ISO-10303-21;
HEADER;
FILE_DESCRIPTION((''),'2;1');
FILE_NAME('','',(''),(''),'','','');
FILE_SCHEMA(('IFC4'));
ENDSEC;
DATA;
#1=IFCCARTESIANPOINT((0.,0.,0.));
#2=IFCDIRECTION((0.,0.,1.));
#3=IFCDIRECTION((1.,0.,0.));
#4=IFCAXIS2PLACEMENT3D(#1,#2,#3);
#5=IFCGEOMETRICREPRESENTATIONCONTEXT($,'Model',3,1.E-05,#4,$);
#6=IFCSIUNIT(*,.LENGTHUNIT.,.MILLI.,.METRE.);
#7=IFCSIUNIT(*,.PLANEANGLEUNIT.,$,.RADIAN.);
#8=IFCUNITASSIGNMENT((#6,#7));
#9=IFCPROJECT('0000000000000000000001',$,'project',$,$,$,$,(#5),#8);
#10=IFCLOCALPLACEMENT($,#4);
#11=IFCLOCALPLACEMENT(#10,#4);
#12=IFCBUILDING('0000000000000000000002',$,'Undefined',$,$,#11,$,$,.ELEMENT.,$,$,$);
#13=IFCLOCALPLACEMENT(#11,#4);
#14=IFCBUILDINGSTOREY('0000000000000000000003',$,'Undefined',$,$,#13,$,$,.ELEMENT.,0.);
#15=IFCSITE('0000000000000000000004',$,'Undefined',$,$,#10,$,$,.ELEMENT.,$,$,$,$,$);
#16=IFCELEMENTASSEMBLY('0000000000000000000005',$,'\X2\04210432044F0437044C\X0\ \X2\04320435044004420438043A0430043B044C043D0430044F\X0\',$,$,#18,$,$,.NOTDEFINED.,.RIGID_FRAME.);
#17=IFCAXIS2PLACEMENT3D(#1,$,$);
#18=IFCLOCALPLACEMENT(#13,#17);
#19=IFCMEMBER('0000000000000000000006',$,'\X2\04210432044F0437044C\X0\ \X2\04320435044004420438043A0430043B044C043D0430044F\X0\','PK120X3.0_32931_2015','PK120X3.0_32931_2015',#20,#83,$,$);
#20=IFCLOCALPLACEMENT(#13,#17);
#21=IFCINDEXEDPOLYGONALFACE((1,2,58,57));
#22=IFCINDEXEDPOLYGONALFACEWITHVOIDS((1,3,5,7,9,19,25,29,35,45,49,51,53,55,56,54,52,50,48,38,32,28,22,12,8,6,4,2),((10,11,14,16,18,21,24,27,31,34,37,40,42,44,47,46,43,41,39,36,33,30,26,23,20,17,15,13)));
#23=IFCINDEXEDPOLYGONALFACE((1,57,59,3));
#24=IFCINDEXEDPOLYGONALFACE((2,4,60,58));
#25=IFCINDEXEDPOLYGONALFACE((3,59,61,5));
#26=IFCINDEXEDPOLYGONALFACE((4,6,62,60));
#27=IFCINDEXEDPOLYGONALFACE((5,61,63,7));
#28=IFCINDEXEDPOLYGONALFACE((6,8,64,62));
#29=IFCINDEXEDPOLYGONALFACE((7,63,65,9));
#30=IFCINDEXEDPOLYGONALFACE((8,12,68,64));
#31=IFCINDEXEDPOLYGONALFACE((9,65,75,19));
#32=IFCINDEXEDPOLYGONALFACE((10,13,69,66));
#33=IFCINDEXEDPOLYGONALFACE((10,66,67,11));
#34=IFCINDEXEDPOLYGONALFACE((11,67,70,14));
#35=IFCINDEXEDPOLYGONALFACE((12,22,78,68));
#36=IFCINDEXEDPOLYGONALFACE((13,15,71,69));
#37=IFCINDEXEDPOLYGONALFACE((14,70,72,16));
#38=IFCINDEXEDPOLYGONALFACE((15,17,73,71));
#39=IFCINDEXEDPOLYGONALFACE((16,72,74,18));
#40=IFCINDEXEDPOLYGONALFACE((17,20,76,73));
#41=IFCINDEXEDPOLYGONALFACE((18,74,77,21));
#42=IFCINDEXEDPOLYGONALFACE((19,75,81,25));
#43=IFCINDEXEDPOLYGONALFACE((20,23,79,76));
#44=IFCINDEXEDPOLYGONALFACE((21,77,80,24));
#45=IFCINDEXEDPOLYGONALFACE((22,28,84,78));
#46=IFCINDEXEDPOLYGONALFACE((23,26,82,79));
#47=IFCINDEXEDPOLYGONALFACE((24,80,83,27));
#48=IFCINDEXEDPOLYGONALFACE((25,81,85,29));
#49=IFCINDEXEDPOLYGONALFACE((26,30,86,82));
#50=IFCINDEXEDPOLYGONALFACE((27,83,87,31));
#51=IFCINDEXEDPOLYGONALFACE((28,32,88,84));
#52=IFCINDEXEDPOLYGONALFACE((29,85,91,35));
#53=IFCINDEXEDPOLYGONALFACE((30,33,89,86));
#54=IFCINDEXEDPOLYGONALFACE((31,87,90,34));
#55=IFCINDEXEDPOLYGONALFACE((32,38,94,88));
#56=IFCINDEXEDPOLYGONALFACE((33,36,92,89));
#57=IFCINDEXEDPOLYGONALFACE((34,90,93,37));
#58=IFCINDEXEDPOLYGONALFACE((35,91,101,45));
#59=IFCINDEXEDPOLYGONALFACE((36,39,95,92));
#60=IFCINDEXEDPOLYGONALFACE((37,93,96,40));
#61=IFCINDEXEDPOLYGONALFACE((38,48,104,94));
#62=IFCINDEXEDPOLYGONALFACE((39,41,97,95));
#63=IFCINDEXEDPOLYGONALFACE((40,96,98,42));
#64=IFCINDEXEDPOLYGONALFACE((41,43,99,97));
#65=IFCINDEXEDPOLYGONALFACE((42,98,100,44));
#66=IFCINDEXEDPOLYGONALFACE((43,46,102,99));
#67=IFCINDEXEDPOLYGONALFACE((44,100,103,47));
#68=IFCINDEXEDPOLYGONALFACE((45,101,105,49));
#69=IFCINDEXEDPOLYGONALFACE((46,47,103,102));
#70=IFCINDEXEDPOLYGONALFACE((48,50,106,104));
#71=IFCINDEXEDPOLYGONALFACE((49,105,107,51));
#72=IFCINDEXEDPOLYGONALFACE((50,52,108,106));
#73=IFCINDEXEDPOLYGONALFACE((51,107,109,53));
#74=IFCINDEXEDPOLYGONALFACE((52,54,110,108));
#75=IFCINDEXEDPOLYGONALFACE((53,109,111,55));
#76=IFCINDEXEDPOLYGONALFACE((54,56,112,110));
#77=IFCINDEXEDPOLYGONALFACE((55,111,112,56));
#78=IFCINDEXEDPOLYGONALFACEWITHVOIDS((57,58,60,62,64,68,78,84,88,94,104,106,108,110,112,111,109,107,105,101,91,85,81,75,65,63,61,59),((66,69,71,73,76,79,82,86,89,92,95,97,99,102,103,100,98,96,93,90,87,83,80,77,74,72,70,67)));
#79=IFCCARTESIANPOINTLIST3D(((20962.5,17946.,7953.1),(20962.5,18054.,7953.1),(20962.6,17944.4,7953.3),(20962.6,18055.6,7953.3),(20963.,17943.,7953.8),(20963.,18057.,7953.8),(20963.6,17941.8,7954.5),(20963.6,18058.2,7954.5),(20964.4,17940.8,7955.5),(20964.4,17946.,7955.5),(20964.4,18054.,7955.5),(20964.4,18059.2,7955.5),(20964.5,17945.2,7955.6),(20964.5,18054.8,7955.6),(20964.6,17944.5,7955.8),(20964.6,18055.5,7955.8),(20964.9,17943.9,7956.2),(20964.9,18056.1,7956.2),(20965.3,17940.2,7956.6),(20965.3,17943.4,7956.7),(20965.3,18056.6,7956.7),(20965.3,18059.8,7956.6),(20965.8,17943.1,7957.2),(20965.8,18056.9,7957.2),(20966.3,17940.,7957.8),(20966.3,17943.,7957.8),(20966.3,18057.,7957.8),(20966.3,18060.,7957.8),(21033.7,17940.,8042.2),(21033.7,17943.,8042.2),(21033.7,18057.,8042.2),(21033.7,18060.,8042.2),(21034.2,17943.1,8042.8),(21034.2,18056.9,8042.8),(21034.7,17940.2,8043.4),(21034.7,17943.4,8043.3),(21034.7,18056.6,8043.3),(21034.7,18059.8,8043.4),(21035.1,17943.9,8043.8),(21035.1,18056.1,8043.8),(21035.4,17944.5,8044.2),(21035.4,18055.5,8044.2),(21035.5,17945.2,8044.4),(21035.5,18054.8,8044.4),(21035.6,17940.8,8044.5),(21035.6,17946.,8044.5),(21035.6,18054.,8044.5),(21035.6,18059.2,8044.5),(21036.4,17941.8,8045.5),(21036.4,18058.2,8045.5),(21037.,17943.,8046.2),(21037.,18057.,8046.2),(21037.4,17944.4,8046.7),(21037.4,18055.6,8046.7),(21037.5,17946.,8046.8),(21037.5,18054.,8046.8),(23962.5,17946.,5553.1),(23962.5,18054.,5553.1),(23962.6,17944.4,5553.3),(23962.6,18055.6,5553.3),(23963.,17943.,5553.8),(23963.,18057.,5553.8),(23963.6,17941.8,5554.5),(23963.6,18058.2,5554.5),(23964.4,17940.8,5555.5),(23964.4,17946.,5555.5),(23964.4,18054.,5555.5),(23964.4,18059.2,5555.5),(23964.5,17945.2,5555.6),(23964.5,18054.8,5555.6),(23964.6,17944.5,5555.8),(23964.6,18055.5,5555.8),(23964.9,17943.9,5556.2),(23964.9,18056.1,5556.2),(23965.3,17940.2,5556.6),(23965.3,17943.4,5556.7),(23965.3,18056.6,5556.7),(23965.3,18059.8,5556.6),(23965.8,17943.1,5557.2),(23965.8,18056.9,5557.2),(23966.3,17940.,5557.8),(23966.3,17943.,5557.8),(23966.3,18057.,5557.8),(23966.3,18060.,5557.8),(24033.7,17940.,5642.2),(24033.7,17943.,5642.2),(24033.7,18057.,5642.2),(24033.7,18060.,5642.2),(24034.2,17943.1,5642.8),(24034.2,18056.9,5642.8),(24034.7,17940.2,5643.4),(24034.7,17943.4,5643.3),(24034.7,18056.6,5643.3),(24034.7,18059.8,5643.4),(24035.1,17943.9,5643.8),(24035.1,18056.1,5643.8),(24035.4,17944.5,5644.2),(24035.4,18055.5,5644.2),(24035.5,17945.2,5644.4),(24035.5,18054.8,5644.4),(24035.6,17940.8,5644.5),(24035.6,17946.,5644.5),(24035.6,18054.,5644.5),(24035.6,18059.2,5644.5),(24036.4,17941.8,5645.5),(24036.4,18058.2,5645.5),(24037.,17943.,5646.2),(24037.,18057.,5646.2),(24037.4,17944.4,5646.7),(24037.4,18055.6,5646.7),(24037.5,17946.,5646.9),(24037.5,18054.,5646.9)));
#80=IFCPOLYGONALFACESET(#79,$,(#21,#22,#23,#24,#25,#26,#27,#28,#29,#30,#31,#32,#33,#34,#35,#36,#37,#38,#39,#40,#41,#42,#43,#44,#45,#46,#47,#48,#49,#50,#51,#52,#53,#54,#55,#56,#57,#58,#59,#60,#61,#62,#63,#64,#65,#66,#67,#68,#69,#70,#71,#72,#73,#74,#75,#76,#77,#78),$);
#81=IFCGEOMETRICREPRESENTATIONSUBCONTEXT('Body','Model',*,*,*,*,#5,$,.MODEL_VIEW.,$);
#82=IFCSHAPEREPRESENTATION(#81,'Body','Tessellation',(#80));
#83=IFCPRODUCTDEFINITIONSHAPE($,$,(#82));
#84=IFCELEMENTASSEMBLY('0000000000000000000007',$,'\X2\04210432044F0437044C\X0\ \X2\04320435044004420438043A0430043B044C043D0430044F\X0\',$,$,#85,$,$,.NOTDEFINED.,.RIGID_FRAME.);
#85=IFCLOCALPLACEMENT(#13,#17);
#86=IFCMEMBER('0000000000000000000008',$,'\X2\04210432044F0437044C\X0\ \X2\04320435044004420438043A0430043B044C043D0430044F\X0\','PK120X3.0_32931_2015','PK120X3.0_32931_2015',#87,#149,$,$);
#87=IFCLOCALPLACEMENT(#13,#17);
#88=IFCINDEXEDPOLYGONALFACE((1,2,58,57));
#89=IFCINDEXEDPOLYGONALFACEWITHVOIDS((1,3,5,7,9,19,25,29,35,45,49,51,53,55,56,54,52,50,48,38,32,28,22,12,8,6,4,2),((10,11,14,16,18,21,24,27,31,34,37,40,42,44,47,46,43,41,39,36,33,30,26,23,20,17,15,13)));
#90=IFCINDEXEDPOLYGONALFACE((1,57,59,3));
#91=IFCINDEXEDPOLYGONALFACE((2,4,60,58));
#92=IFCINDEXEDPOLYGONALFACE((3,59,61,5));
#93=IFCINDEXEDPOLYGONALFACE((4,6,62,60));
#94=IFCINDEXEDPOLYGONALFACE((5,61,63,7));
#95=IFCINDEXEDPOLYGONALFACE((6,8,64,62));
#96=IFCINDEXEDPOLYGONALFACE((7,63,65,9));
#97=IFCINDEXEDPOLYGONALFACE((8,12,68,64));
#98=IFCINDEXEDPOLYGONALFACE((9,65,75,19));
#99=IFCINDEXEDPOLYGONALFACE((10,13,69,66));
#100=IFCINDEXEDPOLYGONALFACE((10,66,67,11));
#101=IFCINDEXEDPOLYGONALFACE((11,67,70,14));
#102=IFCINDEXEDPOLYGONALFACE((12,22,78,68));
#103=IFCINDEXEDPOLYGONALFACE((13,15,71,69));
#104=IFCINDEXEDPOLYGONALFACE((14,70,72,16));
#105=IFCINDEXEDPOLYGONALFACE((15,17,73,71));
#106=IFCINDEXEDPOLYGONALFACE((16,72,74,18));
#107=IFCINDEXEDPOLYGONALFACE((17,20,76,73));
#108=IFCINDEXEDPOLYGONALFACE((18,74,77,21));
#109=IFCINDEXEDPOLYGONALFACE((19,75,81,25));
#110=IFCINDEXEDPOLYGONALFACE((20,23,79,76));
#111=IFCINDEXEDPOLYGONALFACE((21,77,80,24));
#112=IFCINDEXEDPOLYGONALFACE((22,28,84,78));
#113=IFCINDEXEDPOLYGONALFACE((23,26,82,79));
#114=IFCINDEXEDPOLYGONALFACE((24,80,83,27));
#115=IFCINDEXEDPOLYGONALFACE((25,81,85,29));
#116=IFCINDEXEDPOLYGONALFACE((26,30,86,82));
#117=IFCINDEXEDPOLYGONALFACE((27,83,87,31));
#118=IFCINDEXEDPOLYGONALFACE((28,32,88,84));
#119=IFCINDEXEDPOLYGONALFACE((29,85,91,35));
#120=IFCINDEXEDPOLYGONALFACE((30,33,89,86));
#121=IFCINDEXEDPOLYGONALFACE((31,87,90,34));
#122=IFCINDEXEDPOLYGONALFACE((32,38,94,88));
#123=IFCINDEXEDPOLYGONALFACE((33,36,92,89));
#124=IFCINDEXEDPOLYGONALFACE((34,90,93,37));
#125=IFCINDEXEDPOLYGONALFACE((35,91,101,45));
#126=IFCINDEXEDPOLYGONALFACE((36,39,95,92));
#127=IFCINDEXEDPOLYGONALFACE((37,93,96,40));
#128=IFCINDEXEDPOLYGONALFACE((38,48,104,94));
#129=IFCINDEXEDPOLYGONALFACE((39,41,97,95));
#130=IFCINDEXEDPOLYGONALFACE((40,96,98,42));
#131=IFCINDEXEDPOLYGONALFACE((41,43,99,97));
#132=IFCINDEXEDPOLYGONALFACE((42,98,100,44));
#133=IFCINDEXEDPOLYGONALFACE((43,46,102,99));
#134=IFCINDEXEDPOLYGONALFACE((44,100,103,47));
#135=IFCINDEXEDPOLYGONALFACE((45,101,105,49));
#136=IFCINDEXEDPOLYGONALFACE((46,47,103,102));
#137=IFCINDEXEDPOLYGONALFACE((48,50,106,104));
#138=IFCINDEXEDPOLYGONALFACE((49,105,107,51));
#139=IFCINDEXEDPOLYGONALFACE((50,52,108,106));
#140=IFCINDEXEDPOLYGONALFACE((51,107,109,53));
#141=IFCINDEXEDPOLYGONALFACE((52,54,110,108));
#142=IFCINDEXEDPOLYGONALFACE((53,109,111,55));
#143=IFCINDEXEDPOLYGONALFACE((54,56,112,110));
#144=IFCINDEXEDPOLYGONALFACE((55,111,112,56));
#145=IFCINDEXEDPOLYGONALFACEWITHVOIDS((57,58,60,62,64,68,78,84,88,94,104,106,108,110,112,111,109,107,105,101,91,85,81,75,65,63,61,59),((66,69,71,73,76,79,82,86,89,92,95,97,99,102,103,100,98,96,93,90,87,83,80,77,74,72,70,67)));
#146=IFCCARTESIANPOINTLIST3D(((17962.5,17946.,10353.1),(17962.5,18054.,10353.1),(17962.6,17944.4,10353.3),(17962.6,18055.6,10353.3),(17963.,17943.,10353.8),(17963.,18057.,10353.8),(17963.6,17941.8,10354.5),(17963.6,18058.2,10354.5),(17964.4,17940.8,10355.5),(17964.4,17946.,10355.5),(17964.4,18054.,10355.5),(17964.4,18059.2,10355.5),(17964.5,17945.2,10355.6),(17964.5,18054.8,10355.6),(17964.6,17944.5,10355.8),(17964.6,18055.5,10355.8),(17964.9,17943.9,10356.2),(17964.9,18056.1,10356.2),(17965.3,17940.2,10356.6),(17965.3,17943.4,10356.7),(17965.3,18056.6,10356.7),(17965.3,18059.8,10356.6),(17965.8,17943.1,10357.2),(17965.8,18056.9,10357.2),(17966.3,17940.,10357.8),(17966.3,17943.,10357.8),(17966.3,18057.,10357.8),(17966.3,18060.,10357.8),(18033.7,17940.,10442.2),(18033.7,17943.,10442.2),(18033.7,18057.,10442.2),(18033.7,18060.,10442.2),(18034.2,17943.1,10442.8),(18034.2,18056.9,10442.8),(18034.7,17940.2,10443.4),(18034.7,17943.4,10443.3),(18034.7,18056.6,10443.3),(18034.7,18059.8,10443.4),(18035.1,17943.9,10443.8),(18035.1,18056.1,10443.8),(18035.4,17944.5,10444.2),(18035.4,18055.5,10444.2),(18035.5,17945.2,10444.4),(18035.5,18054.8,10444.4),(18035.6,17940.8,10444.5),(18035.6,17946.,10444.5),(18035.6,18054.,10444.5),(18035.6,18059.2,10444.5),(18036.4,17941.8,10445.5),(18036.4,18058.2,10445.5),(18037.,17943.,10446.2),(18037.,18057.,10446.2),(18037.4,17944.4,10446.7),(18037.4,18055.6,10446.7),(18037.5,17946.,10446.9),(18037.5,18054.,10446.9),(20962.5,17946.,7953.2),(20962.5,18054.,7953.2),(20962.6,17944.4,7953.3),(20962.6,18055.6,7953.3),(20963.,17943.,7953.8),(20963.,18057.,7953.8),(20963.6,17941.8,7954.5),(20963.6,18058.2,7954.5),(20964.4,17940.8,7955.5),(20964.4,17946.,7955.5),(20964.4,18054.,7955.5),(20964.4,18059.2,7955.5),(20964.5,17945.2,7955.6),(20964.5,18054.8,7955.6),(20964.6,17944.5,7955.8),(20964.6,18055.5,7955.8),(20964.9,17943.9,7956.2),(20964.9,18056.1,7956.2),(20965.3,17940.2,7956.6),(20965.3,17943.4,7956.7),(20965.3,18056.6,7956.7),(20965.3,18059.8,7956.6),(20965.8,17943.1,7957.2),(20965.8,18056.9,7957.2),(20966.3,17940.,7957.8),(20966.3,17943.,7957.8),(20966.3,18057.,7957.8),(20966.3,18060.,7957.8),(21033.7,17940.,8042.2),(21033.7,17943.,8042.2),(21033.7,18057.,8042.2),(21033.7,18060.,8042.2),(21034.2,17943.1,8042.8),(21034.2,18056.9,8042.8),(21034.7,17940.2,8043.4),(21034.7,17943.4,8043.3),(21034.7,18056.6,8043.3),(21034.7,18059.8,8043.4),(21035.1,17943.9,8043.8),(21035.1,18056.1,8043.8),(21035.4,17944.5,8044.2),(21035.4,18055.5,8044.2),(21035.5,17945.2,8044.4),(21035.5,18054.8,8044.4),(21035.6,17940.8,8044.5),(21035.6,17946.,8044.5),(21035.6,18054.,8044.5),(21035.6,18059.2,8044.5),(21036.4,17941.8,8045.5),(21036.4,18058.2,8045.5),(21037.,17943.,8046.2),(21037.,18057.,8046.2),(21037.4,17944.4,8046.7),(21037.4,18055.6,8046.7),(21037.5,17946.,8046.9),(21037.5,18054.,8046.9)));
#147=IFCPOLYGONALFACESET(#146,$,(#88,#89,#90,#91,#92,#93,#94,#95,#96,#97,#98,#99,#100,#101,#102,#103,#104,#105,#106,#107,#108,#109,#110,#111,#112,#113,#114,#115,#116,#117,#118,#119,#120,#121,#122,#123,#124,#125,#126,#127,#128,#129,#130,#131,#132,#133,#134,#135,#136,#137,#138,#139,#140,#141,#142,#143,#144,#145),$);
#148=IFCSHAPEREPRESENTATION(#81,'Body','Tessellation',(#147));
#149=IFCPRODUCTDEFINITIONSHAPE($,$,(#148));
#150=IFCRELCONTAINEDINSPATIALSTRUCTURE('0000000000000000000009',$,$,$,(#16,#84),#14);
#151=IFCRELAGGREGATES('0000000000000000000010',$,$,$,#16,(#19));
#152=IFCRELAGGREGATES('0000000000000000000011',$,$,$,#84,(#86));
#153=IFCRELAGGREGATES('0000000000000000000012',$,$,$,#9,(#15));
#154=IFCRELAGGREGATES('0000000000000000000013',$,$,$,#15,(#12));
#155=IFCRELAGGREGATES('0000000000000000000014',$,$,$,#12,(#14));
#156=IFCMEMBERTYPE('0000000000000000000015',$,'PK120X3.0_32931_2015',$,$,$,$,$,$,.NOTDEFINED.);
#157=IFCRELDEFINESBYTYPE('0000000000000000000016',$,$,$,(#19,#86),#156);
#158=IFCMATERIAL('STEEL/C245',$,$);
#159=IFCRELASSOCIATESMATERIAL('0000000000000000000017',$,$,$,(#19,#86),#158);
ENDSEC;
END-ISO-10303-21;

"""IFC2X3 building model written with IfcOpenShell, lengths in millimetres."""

from ifc_helpers import new_model, si_unit, frame, origin_with_axes, origin_2d_with_axis, place, context, subcontext, project, spatial, hollow_rectangle, extrude, material, type_object, element, aggregate, save


model = new_model("IFC2X3")

# Units and contexts
model_context = context("Model", 3, precision=1e-05, world=origin_with_axes())
body_context = subcontext(model_context, "Body", "Model", "MODEL_VIEW")
ifc_project = project(units=[si_unit("LENGTHUNIT", "METRE", prefix="MILLI"), si_unit("PLANEANGLEUNIT", "RADIAN")], contexts=[model_context])

# Site, building, storey
site_placement = place(None, origin_with_axes())
site = spatial("IfcSite", under=ifc_project, at=site_placement, Name="Undefined", CompositionType="ELEMENT")
building_placement = place(site_placement, origin_with_axes())
building = spatial("IfcBuilding", under=site, at=building_placement, Name="Undefined", CompositionType="ELEMENT")
storey_placement = place(building_placement, origin_with_axes())
storey = spatial("IfcBuildingStorey", under=building, at=storey_placement, Name="Undefined", CompositionType="ELEMENT", Elevation=0.0)

# Shared definitions
ifc_material_1 = material(Name="STEEL/C245")

# Element assemblies, members
member_type_1 = type_object("IfcMemberType", Name="PK120X3.0_32931_2015", PredefinedType="NOTDEFINED")
assembly_1_placement = place(storey_placement, origin_with_axes())
assembly_1 = element("IfcElementAssembly", 1, at=assembly_1_placement, inside=storey, Name="Связь вертикальная", AssemblyPlace="NOTDEFINED", PredefinedType="RIGID_FRAME")
member_1_placement = place(assembly_1_placement, frame((21000.0, 18000.0, 8000.0), z_axis=(-0.624695, 0.0, -0.780869), x_axis=(0.780869, 0.0, -0.624695)))
member_1 = element("IfcMember", 2, at=member_1_placement, type_object=member_type_1, material=ifc_material_1, Name="Связь вертикальная", Description="PK120X3.0_32931_2015", ObjectType="PK120X3.0_32931_2015", context=body_context, shape_type="SweptSolid", body=[
    extrude(hollow_rectangle(XDim=120.0, YDim=120.0, WallThickness=3.0, InnerFilletRadius=3.0, OuterFilletRadius=6.0, at=origin_2d_with_axis()), frame((3841.9, 0.0, 0.0), z_axis=(-1.0, 0.0, 0.0), x_axis=(0.0, -1.0, 0.0)), (0.0, 0.0, 1.0), 3841.9),
])
aggregate(assembly_1, [member_1])
assembly_2_placement = place(storey_placement, origin_with_axes())
assembly_2 = element("IfcElementAssembly", 3, at=assembly_2_placement, inside=storey, Name="Связь вертикальная", AssemblyPlace="NOTDEFINED", PredefinedType="RIGID_FRAME")
member_2_placement = place(assembly_2_placement, frame((21000.0, 18000.0, 8000.0), z_axis=(0.624695, 0.0, 0.780869), x_axis=(-0.780869, 0.0, 0.624695)))
member_2 = element("IfcMember", 4, at=member_2_placement, type_object=member_type_1, material=ifc_material_1, Name="Связь вертикальная", Description="PK120X3.0_32931_2015", ObjectType="PK120X3.0_32931_2015", context=body_context, shape_type="SweptSolid", body=[
    extrude(hollow_rectangle(XDim=120.0, YDim=120.0, WallThickness=3.0, InnerFilletRadius=3.0, OuterFilletRadius=6.0, at=origin_2d_with_axis()), frame((3841.9, 0.0, 0.0), z_axis=(-1.0, 0.0, 0.0), x_axis=(0.0, -1.0, 0.0)), (0.0, 0.0, 1.0), 3841.9),
])
aggregate(assembly_2, [member_2])

save(model, "model.ifc")
